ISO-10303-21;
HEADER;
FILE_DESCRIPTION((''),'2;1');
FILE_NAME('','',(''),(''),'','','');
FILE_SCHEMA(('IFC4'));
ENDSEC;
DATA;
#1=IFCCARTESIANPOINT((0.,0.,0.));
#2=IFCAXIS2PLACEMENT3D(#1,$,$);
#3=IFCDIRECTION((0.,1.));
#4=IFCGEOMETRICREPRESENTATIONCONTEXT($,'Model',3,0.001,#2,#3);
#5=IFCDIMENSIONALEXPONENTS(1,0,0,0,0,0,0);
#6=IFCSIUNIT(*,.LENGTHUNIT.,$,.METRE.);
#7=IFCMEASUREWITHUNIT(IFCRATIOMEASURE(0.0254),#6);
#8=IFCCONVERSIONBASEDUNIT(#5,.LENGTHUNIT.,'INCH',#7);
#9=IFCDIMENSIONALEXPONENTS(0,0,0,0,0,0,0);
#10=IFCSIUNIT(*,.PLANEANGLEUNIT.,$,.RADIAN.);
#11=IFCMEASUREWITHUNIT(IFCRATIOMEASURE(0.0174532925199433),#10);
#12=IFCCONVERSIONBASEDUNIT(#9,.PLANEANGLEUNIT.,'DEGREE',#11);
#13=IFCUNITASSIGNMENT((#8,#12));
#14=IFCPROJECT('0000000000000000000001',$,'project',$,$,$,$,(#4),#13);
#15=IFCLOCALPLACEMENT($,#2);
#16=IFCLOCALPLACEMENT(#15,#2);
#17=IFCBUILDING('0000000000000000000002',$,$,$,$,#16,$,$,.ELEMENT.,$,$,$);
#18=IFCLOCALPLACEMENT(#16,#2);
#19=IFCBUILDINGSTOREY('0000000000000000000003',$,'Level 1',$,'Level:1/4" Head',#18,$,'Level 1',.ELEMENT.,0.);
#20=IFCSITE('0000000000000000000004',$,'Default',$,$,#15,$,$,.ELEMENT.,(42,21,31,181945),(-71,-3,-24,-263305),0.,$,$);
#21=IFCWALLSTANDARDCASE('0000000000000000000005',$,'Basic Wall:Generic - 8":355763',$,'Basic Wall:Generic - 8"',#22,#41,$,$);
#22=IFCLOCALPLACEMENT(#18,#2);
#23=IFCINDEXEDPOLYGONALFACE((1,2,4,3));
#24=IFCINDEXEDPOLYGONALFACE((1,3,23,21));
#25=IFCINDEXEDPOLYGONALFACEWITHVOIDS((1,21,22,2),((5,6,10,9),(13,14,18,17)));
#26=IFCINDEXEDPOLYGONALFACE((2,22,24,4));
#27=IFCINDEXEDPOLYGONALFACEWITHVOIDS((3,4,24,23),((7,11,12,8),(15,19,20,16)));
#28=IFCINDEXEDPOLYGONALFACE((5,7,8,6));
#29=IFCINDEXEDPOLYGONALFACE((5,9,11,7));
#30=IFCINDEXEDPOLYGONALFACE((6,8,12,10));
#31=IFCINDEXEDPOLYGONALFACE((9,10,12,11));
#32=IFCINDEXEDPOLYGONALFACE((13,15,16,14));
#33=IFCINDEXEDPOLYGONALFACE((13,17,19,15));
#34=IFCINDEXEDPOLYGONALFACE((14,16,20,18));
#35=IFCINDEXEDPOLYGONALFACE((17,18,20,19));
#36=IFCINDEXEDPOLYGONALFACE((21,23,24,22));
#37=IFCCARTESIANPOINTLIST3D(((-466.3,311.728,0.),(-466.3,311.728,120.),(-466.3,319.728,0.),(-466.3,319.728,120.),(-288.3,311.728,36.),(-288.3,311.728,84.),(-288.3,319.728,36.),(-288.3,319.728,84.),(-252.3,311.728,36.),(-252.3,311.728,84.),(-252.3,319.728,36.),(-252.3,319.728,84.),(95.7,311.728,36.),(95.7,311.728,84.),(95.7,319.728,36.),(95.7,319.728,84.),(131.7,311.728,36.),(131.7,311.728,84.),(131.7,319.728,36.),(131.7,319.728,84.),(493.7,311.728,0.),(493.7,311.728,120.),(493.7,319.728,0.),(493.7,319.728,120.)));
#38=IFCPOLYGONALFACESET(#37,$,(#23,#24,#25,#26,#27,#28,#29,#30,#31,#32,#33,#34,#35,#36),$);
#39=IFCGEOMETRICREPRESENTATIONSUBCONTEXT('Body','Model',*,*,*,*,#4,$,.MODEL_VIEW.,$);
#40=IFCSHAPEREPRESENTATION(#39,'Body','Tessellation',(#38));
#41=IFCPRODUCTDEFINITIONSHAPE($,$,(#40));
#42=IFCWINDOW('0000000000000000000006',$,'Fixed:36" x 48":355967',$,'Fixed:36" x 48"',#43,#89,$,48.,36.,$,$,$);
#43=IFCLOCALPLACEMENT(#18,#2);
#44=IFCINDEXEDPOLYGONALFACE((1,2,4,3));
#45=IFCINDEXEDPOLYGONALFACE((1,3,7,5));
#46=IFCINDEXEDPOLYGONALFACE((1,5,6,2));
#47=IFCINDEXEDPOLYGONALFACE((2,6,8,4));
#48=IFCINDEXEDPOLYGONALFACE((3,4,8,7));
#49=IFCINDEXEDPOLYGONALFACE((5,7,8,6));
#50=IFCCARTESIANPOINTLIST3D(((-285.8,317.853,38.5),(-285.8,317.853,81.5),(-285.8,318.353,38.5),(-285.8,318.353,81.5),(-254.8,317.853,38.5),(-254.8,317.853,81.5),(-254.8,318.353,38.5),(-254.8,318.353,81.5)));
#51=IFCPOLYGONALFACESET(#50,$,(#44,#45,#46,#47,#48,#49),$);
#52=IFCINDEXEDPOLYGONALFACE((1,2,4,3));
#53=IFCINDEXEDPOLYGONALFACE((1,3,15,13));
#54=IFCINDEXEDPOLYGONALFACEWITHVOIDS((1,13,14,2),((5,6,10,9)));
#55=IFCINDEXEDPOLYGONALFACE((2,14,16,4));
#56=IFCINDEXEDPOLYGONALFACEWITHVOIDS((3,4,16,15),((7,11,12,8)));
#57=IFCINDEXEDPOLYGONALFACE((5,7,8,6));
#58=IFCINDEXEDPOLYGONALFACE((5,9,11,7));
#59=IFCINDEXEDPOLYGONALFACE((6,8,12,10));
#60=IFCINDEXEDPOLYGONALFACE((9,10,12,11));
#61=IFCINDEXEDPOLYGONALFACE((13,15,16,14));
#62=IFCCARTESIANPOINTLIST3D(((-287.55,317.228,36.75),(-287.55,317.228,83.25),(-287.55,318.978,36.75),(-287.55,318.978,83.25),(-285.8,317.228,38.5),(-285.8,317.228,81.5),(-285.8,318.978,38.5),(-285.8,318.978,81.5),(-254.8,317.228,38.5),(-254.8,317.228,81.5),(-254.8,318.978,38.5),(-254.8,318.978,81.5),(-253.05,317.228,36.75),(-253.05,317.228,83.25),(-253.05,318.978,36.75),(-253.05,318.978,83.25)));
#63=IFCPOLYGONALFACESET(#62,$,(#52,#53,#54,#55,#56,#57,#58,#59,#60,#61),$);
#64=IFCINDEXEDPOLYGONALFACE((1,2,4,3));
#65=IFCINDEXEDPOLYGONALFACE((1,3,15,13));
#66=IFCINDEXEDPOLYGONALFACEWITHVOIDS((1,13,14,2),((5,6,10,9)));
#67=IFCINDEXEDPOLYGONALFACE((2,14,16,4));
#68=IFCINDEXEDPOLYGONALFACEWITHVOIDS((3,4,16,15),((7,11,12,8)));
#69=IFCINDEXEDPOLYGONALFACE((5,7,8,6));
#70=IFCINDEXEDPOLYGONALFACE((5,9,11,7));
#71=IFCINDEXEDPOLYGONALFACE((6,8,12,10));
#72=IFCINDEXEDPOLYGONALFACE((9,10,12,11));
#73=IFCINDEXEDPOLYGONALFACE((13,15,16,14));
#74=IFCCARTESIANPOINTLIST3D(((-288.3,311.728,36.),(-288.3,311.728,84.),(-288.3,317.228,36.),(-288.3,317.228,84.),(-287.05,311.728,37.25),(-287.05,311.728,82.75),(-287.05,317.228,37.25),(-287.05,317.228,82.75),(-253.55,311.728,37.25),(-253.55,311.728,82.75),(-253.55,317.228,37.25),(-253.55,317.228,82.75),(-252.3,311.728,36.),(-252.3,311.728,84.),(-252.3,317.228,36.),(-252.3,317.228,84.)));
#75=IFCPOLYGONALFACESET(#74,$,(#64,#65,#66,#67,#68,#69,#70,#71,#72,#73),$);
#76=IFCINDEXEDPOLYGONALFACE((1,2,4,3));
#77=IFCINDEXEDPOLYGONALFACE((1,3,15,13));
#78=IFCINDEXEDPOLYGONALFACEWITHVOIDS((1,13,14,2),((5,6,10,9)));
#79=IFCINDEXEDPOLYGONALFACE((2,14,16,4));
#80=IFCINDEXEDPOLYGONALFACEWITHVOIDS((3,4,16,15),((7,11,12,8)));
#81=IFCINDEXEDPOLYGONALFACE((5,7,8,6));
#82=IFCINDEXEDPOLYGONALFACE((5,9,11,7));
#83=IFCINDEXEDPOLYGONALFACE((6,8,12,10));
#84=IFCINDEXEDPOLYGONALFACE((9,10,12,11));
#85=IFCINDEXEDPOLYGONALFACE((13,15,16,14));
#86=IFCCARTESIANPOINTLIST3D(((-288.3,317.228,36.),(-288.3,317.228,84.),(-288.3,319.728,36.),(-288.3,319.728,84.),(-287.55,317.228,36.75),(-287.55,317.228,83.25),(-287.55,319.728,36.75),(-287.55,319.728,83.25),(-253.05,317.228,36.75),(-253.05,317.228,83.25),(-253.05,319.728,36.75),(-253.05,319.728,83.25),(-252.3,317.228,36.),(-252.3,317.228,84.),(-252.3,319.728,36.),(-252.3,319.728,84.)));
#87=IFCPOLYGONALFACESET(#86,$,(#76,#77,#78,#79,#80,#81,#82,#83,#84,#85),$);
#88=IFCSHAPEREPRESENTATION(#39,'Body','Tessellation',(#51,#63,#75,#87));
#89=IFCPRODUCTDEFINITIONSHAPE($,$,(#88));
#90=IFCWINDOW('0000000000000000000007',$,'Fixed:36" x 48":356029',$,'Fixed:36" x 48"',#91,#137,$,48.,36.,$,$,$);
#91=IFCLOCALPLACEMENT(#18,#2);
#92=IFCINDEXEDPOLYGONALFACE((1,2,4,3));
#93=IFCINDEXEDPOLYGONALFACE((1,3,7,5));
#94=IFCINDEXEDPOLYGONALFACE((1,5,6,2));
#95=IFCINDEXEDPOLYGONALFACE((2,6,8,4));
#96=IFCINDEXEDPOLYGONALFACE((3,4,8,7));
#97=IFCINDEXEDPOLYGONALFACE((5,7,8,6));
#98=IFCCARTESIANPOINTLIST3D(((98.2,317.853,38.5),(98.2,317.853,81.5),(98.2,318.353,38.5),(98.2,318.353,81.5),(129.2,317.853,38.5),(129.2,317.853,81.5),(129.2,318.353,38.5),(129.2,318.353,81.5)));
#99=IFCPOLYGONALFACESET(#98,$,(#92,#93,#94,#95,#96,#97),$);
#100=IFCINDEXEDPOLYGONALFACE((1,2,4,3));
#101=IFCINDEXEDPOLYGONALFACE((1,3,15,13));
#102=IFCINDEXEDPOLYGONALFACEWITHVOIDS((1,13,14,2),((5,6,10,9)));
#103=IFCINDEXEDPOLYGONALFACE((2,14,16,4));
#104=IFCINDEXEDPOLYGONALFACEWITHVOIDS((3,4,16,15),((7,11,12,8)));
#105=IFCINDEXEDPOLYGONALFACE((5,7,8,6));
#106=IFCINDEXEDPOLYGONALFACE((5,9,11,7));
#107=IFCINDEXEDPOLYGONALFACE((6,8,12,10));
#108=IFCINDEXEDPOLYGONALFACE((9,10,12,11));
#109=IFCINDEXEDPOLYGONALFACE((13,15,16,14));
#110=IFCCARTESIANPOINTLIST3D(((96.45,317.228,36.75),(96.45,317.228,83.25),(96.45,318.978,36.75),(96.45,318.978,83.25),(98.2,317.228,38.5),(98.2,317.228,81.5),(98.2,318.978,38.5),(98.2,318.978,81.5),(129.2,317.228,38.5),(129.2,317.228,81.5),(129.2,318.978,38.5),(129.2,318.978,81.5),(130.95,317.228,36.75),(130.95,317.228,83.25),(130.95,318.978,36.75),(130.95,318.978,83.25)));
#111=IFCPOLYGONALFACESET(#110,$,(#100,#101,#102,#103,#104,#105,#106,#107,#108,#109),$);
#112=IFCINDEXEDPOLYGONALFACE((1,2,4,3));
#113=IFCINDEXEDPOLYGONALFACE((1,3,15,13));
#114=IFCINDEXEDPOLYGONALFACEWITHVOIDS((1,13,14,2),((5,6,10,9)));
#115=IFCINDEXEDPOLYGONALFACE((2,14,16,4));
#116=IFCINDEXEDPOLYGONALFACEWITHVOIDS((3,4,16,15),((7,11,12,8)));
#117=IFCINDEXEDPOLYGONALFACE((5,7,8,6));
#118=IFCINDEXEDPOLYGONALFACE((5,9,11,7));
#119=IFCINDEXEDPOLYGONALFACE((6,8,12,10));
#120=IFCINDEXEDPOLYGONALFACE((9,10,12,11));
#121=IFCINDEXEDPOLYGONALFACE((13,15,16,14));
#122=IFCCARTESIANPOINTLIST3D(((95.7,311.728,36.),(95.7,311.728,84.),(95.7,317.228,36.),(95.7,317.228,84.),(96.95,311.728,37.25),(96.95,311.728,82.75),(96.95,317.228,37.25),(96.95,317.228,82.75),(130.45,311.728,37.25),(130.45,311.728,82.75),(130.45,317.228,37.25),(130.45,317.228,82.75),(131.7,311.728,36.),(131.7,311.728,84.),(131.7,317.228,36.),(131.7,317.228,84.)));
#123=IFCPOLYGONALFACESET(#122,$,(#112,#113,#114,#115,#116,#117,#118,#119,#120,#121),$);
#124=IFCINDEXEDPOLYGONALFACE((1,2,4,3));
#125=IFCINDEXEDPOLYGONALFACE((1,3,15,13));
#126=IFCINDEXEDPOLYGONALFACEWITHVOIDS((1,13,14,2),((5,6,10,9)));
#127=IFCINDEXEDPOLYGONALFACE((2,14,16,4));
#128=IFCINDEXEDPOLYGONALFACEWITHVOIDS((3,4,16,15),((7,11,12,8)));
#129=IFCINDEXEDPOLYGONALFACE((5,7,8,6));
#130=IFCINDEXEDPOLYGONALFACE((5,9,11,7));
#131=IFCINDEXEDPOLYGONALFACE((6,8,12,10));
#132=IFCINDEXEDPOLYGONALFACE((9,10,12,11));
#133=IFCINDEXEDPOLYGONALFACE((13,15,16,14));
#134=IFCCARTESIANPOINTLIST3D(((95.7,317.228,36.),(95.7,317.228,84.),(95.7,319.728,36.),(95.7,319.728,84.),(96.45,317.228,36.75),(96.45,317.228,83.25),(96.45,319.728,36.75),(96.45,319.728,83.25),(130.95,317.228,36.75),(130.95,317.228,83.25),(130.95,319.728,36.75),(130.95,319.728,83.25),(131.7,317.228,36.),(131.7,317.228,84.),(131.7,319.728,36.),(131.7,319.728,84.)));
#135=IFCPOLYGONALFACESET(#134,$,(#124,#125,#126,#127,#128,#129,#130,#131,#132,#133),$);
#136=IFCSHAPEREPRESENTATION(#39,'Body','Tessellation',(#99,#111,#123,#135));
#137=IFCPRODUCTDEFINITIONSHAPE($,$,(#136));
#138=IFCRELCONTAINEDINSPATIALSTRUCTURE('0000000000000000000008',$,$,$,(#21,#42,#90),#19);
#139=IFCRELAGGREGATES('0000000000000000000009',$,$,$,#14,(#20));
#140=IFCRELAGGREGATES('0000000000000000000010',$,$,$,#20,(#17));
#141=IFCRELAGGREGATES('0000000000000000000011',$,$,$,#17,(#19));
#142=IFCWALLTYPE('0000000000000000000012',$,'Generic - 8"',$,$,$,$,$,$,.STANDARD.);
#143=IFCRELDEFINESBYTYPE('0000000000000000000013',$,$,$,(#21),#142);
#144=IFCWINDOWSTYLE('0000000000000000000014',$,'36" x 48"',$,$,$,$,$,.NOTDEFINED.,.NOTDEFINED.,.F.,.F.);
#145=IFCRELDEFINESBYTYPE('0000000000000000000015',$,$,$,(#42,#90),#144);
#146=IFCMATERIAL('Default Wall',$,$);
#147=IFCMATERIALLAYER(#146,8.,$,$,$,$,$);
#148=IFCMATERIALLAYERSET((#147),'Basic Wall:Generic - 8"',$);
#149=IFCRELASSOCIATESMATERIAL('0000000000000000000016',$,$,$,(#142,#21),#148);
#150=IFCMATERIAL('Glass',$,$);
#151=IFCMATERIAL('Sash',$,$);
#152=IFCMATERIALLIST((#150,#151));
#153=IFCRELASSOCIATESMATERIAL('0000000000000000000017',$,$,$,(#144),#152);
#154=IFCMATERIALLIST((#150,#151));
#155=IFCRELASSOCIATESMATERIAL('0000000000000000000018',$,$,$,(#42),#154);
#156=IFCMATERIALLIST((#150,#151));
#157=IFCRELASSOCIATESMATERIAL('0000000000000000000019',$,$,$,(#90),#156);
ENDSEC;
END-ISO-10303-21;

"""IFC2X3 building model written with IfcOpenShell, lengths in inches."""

from ifc_helpers import new_model, entity, si_unit, converted_unit, direction, frame, frame_2d, origin, place, context, subcontext, project, spatial, polyline, rectangle, outline, extrude, clip, halfspace, source, transform, mapped, material, material_list, layer, layer_set, layer_usage, type_object, type_shapes, element, fill, save


model = new_model("IFC2X3")

# Units and contexts
model_context = context("Model", 3, precision=0.001, world=origin(), true_north=direction((0.0, 1.0)))
body_context = subcontext(model_context, "Body", "Model", "MODEL_VIEW")
ifc_project = project(units=[converted_unit("LENGTHUNIT", "INCH", entity("IfcRatioMeasure", 0.0254), si_unit("LENGTHUNIT", "METRE"), dimensions=[1, 0, 0, 0, 0, 0, 0]), converted_unit("PLANEANGLEUNIT", "DEGREE", entity("IfcRatioMeasure", 0.0174532925199433), si_unit("PLANEANGLEUNIT", "RADIAN"), dimensions=[0, 0, 0, 0, 0, 0, 0])], contexts=[model_context])

# Site, building, storey
site_placement = place(None, origin())
site = spatial("IfcSite", under=ifc_project, at=site_placement, Name="Default", CompositionType="ELEMENT", RefLatitude=(42, 21, 31, 181945), RefLongitude=(-71, -3, -24, -263305), RefElevation=0.0)
building_placement = place(site_placement, origin())
building = spatial("IfcBuilding", under=site, at=building_placement, CompositionType="ELEMENT")
storey_placement = place(building_placement, origin())
storey = spatial("IfcBuildingStorey", under=building, at=storey_placement, Name="Level 1", ObjectType="Level:1/4\" Head", LongName="Level 1", CompositionType="ELEMENT", Elevation=0.0)

# Wall, openings, windows
ifc_material_1 = material(Name="Default Wall")
ifc_layer = layer(ifc_material_1, 8.0)
ifc_layer_set = layer_set([ifc_layer], Name="Basic Wall:Generic - 8\"")
ifc_layer_usage_1 = layer_usage(ifc_layer_set, "AXIS2", "NEGATIVE", 4.0)
wall_type = type_object("IfcWallType", Name="Generic - 8\"", PredefinedType="STANDARD", material=ifc_layer_set)
wall_1_placement = place(storey_placement, frame((-466.3, 315.728, 0.0)))
wall_1 = element("IfcWallStandardCase", 1, at=wall_1_placement, inside=storey, type_object=wall_type, material=ifc_layer_usage_1, Name="Basic Wall:Generic - 8\":355763", ObjectType="Basic Wall:Generic - 8\"", context=body_context, shape_type="Clipping", body=[
    clip(extrude(rectangle(XDim=960.0, YDim=8.0, at=frame_2d((480.0, 0.0), x_axis=(-1.0, 0.0))), origin(), (0.0, 0.0, 1.0), 120.0), halfspace(origin(), True)),
])
opening_1_placement = place(wall_1_placement, frame((178.0, -4.0, 36.0)))
opening_1 = element("IfcOpeningElement", 2, at=opening_1_placement, cuts=wall_1, ObjectType="Opening", context=body_context, shape_type="SweptSolid", body=[
    extrude(rectangle(XDim=48.0, YDim=36.0, at=frame_2d((24.0, 18.0), x_axis=(-1.0, 0.0))), frame((0.0, 0.0, 0.0), z_axis=(0.0, 1.0, 0.0), x_axis=(0.0, 0.0, 1.0)), (0.0, 0.0, 1.0), 8.0),
])
opening_2_placement = place(wall_1_placement, frame((562.0, -4.0, 36.0)))
opening_2 = element("IfcOpeningElement", 3, at=opening_2_placement, cuts=wall_1, ObjectType="Opening", context=body_context, shape_type="SweptSolid", body=[
    extrude(rectangle(XDim=48.0, YDim=36.0, at=frame_2d((24.0, 18.0), x_axis=(-1.0, 0.0))), frame((0.0, 0.0, 0.0), z_axis=(0.0, 1.0, 0.0), x_axis=(0.0, 0.0, 1.0)), (0.0, 0.0, 1.0), 8.0),
])
ifc_material_2 = material(Name="Glass")
ifc_material_3 = material(Name="Sash")
ifc_material_list_1 = material_list([ifc_material_2, ifc_material_3])
ifc_material_list_2 = material_list([ifc_material_2, ifc_material_3])
window_style = type_object("IfcWindowStyle", Name="36\" x 48\"", ConstructionType="NOTDEFINED", OperationType="NOTDEFINED", ParameterTakesPrecedence=False, Sizeable=False, material=ifc_material_list_2)
shared_shape_1 = source(origin(), body_context, "Body", "SweptSolid", [
    extrude(rectangle(XDim=0.5, YDim=31.0, at=frame_2d((0.0, 0.0), x_axis=(1.0, 0.0))), frame((18.0, 6.375, 2.5), z_axis=(0.0, 0.0, 1.0), x_axis=(0.0, 1.0, 0.0)), (0.0, 0.0, 1.0), 43.0),
    extrude(outline(polyline([(-17.25, -23.25), (17.25, -23.25), (17.25, 23.25), (-17.25, 23.25), (-17.25, -23.25)]), holes=[polyline([(-15.5, -21.5), (-15.5, 21.5), (15.5, 21.5), (15.5, -21.5), (-15.5, -21.5)])]), frame((18.0, 5.5, 24.0), z_axis=(0.0, 1.0, 0.0), x_axis=(1.0, 0.0, 0.0)), (0.0, 0.0, 1.0), 1.75),
    extrude(outline(polyline([(-18.0, -24.0), (18.0, -24.0), (18.0, 24.0), (-18.0, 24.0), (-18.0, -24.0)]), holes=[polyline([(-16.75, -22.75), (-16.75, 22.75), (16.75, 22.75), (16.75, -22.75), (-16.75, -22.75)])]), frame((18.0, 0.0, 24.0), z_axis=(0.0, 1.0, 0.0), x_axis=(1.0, 0.0, 0.0)), (0.0, 0.0, 1.0), 5.5),
    extrude(outline(polyline([(-24.0, -18.0), (24.0, -18.0), (24.0, 18.0), (-24.0, 18.0), (-24.0, -18.0)]), holes=[polyline([(-23.25, -17.25), (-23.25, 17.25), (23.25, 17.25), (23.25, -17.25), (-23.25, -17.25)])]), frame((18.0, 5.5, 24.0), z_axis=(0.0, 1.0, 0.0), x_axis=(0.0, 0.0, -1.0)), (0.0, 0.0, 1.0), 2.5),
])
type_shapes(window_style, [shared_shape_1])
window_1_placement = place(opening_1_placement, origin())
window_1 = element("IfcWindow", 4, at=window_1_placement, inside=storey, type_object=window_style, material=ifc_material_list_1, Name="Fixed:36\" x 48\":355967", ObjectType="Fixed:36\" x 48\"", OverallHeight=48.0, OverallWidth=36.0, context=body_context, shape_type="MappedRepresentation", body=[
    mapped(shared_shape_1, transform((0.0, 0.0, 0.0), scale=1.0)),
])
fill(opening_1, window_1)
ifc_material_list_3 = material_list([ifc_material_2, ifc_material_3])
window_2_placement = place(opening_2_placement, origin())
window_2 = element("IfcWindow", 5, at=window_2_placement, inside=storey, type_object=window_style, material=ifc_material_list_3, Name="Fixed:36\" x 48\":356029", ObjectType="Fixed:36\" x 48\"", OverallHeight=48.0, OverallWidth=36.0, context=body_context, shape_type="MappedRepresentation", body=[
    mapped(shared_shape_1, transform((0.0, 0.0, 0.0), scale=1.0)),
])
fill(opening_2, window_2)

save(model, "model.ifc")
